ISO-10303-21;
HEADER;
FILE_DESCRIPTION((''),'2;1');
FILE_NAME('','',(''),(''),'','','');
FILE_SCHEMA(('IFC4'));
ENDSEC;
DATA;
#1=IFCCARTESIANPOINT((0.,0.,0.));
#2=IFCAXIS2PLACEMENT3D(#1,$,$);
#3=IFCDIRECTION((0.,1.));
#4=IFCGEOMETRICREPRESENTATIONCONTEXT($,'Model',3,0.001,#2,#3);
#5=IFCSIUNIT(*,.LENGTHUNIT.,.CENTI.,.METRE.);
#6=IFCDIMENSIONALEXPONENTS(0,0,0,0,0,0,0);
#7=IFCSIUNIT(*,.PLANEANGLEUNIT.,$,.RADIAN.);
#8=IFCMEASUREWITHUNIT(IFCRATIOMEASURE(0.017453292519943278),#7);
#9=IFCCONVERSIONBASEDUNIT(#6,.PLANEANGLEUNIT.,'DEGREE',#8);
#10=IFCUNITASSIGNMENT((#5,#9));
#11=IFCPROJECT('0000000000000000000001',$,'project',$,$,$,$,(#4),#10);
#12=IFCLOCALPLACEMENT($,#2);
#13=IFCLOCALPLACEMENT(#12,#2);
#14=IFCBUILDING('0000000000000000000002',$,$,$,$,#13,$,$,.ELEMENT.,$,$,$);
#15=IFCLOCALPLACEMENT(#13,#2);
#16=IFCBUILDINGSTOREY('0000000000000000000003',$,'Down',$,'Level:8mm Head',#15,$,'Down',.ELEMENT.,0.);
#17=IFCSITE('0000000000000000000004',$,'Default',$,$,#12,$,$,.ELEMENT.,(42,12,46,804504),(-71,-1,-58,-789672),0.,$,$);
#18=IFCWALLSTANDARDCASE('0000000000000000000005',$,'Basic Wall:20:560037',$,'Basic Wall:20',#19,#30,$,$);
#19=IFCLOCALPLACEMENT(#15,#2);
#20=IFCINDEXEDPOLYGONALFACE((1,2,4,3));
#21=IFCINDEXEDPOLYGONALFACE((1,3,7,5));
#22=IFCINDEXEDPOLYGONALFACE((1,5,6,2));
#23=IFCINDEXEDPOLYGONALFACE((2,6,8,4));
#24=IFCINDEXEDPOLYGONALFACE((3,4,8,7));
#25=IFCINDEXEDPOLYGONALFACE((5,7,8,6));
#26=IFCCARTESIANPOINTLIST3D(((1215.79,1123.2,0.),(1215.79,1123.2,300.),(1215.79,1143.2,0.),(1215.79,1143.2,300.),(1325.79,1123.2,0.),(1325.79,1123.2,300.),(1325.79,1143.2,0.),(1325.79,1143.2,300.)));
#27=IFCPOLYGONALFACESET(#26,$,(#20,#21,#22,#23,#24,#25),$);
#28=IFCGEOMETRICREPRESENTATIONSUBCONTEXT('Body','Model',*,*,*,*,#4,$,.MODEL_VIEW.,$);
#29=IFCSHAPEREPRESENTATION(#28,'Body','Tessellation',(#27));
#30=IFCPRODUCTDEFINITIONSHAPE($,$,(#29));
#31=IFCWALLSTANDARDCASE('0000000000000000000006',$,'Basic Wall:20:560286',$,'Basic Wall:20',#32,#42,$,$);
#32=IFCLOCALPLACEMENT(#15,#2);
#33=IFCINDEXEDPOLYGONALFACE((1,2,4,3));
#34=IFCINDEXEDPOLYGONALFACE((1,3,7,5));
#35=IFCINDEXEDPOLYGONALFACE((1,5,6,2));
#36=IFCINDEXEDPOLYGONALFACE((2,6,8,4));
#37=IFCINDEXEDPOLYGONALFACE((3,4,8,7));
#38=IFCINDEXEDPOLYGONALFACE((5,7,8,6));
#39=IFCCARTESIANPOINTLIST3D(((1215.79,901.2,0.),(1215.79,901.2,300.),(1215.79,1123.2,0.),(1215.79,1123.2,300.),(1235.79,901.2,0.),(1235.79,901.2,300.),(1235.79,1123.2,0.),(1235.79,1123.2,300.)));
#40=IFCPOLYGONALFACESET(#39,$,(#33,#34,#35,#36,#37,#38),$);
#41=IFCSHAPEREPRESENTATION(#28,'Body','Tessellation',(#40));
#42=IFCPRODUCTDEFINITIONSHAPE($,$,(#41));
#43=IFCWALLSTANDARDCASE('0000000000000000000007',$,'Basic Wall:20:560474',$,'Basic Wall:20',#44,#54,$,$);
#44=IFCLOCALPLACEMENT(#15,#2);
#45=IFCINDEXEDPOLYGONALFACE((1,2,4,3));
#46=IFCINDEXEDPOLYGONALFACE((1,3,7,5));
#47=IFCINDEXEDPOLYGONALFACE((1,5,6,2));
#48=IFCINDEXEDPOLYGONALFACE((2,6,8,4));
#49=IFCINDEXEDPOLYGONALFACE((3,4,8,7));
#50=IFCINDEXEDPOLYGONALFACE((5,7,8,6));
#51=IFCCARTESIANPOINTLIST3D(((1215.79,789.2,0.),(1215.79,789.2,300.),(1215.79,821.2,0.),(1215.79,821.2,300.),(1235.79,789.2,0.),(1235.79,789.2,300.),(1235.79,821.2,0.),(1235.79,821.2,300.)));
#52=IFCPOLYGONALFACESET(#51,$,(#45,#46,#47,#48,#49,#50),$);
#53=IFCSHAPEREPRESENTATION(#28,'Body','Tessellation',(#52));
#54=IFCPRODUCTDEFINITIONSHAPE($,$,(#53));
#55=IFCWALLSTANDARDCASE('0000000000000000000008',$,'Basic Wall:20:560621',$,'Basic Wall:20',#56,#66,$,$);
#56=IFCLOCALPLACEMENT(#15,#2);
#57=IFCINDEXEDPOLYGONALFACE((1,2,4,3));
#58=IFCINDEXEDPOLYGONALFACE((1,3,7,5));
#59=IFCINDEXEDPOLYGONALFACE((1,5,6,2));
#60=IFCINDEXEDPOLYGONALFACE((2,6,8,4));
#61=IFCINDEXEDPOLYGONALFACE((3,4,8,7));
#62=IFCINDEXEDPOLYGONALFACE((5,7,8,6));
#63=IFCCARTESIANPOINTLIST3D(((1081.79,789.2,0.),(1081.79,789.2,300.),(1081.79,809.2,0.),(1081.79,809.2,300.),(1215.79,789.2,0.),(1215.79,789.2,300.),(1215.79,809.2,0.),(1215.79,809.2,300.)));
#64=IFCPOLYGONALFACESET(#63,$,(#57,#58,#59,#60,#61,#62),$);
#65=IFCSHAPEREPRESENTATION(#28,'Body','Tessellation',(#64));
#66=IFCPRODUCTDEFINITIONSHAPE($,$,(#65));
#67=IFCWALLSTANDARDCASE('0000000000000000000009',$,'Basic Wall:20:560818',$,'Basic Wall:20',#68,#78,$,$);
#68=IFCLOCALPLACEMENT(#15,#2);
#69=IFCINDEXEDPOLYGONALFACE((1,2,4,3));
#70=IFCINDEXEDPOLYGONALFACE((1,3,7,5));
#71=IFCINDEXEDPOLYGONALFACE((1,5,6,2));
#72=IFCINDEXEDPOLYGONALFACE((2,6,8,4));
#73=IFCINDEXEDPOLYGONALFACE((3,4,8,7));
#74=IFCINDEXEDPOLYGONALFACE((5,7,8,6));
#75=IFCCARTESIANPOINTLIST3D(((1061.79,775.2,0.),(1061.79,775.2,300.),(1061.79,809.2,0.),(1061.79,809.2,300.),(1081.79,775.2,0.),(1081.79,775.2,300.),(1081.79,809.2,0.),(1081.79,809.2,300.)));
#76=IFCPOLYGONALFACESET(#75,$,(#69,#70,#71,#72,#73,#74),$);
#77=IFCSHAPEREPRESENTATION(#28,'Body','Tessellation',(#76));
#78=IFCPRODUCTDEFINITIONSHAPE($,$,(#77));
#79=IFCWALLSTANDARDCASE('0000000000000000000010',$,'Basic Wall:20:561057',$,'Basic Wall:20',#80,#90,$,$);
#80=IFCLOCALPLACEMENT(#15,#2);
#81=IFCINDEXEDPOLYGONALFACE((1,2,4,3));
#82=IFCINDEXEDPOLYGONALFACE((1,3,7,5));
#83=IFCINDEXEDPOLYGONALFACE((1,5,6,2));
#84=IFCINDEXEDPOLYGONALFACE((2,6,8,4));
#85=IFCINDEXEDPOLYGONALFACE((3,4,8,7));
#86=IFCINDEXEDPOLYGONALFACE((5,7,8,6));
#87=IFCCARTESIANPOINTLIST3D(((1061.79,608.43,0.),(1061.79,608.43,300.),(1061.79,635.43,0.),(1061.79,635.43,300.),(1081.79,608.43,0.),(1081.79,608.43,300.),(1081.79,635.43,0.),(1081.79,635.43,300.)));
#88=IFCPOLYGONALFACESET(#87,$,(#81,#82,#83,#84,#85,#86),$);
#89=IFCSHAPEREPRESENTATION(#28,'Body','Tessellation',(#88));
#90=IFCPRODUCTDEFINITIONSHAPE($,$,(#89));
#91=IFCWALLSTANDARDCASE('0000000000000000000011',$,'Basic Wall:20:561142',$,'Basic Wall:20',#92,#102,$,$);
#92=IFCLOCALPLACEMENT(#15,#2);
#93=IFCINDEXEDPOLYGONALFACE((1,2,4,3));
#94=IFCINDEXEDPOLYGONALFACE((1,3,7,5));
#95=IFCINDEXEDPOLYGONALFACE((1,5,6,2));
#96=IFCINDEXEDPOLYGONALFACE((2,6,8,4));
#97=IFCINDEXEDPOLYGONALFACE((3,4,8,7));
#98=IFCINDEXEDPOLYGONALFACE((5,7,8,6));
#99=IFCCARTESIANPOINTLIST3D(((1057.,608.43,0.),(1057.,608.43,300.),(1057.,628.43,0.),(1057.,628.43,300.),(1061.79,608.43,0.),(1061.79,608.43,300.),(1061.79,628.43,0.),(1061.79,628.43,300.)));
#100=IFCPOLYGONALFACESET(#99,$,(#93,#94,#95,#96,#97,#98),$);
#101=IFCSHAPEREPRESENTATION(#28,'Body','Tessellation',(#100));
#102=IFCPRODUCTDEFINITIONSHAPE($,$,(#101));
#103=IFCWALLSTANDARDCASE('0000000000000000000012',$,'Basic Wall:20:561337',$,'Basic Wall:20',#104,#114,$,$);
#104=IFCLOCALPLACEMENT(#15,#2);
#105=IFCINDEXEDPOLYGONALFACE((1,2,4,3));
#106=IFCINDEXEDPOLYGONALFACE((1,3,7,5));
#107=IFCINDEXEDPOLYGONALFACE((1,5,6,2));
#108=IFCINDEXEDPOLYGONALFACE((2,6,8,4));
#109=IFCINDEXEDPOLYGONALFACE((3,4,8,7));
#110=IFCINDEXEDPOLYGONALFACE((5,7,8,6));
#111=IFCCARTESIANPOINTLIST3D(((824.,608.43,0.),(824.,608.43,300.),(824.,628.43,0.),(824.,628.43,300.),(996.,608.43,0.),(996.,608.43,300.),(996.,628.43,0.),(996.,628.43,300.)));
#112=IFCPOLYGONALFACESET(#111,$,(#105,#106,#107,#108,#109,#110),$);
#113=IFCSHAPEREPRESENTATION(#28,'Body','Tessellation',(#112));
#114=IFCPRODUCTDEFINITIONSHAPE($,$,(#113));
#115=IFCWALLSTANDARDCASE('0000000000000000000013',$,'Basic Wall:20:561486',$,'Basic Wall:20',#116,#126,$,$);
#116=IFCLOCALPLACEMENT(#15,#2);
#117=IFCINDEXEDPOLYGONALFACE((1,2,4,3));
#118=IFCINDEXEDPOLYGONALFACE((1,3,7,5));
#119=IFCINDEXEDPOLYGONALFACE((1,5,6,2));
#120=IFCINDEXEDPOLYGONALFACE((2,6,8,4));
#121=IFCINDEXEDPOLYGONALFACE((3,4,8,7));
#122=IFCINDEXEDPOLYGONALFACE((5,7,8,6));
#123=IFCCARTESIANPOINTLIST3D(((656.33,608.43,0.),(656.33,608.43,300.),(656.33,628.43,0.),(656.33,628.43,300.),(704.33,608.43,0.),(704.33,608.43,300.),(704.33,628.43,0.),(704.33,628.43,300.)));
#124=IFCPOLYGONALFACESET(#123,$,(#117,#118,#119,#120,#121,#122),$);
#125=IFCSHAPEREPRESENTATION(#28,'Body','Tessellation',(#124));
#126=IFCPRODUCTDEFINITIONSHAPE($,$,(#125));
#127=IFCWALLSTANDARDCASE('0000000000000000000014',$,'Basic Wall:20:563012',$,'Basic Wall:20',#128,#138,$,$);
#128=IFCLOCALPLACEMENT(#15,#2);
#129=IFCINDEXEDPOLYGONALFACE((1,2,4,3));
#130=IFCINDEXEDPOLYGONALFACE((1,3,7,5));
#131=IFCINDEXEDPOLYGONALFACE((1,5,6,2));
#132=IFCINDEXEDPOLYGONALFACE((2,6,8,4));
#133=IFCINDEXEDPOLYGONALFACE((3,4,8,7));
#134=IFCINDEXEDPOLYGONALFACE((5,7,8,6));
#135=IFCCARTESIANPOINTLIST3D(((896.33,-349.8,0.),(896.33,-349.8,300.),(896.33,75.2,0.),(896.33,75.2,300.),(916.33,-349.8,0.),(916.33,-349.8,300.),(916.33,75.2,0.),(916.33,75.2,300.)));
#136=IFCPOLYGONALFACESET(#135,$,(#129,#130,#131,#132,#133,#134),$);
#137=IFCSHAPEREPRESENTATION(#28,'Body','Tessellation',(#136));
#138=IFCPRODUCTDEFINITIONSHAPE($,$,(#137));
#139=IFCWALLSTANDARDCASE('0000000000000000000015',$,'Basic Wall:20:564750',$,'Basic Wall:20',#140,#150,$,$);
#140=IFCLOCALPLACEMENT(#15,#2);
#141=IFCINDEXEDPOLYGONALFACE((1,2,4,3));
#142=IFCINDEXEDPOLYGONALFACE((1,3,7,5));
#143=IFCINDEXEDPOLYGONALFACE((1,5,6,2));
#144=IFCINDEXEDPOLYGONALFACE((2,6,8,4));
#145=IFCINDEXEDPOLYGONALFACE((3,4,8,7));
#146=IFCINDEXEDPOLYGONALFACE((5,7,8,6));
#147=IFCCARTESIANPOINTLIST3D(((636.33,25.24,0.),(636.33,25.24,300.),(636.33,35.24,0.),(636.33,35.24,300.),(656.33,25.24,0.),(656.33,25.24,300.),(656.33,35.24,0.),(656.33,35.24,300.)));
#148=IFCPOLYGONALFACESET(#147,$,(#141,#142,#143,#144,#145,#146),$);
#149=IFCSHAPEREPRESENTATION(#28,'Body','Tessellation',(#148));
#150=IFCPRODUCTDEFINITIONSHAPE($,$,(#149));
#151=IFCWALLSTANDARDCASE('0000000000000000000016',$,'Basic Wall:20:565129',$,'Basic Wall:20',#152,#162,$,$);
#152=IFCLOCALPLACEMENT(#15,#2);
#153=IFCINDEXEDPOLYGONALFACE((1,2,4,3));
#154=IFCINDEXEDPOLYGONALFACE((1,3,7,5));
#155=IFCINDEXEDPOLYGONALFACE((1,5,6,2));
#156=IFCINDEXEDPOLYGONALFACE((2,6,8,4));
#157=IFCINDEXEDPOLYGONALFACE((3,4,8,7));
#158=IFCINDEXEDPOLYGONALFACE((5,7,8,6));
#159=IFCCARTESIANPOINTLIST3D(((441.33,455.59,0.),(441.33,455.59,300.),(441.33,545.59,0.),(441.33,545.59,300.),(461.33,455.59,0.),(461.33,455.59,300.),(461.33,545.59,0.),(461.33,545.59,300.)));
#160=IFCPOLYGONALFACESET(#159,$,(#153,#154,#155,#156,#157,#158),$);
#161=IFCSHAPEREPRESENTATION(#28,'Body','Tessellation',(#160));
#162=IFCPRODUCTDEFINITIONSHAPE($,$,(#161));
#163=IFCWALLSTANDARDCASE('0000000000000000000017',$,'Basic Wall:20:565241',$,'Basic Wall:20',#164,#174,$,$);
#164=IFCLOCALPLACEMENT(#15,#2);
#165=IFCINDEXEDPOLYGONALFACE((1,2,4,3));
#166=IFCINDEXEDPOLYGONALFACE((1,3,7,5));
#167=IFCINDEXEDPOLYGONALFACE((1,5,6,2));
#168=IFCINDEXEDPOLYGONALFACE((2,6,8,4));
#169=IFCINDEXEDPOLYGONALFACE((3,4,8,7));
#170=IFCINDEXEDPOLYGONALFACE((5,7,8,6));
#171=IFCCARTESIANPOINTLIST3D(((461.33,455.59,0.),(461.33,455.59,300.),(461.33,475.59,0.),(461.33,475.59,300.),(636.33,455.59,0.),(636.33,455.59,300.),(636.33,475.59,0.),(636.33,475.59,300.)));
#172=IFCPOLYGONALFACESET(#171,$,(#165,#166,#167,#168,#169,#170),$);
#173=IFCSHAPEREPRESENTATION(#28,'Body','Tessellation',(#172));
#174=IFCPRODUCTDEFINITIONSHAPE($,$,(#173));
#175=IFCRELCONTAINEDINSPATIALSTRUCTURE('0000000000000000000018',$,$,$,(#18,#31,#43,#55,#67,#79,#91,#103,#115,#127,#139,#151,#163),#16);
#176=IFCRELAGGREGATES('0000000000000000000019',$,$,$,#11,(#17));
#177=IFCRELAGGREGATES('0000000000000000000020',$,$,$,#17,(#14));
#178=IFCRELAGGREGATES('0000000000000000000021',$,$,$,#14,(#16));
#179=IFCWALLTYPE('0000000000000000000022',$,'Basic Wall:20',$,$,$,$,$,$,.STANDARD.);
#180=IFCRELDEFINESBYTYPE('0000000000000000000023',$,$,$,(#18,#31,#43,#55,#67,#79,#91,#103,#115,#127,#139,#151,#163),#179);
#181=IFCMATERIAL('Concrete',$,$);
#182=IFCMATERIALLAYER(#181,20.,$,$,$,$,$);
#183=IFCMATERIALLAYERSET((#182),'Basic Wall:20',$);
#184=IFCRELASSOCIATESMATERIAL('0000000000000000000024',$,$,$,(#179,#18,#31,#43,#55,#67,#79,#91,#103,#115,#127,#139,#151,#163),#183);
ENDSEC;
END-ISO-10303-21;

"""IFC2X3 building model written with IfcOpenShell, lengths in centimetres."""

from ifc_helpers import new_model, entity, si_unit, converted_unit, direction, frame, frame_2d, origin, place, context, subcontext, project, spatial, rectangle, extrude, material, layer, layer_set, layer_usage, type_object, element, save


model = new_model("IFC2X3")

# Units and contexts
model_context = context("Model", 3, precision=0.001, world=origin(), true_north=direction((0.0, 1.0)))
body_context = subcontext(model_context, "Body", "Model", "MODEL_VIEW")
ifc_project = project(units=[si_unit("LENGTHUNIT", "METRE", prefix="CENTI"), converted_unit("PLANEANGLEUNIT", "DEGREE", entity("IfcRatioMeasure", 0.017453292519943278), si_unit("PLANEANGLEUNIT", "RADIAN"), dimensions=[0, 0, 0, 0, 0, 0, 0])], contexts=[model_context])

# Site, building, storey
site_placement = place(None, origin())
site = spatial("IfcSite", under=ifc_project, at=site_placement, Name="Default", CompositionType="ELEMENT", RefLatitude=(42, 12, 46, 804504), RefLongitude=(-71, -1, -58, -789672), RefElevation=0.0)
building_placement = place(site_placement, origin())
building = spatial("IfcBuilding", under=site, at=building_placement, CompositionType="ELEMENT")
storey_placement = place(building_placement, origin())
storey = spatial("IfcBuildingStorey", under=building, at=storey_placement, Name="Down", ObjectType="Level:8mm Head", LongName="Down", CompositionType="ELEMENT", Elevation=0.0)

# Walls
ifc_material = material(Name="Concrete")
ifc_layer_1 = layer(ifc_material, 20.0)
ifc_layer_set_1 = layer_set([ifc_layer_1], Name="Basic Wall:20")
wall_type_1 = type_object("IfcWallType", Name="Basic Wall:20", PredefinedType="STANDARD", material=ifc_layer_set_1)
ifc_layer_usage_1 = layer_usage(ifc_layer_set_1, "AXIS2", "POSITIVE", -10.0)
wall_1_placement = place(storey_placement, frame((1325.79, 1133.2, 0.0), z_axis=(0.0, 0.0, 1.0), x_axis=(-1.0, 0.0, 0.0)))
element("IfcWallStandardCase", 1, at=wall_1_placement, inside=storey, type_object=wall_type_1, material=ifc_layer_usage_1, Name="Basic Wall:20:560037", ObjectType="Basic Wall:20", context=body_context, shape_type="SweptSolid", body=[
    extrude(rectangle(XDim=110.0, YDim=20.0, at=frame_2d((55.0, 0.0), x_axis=(-1.0, 0.0))), origin(), (0.0, 0.0, 1.0), 300.0),
])
ifc_layer_usage_2 = layer_usage(ifc_layer_set_1, "AXIS2", "NEGATIVE", 10.0)
wall_2_placement = place(storey_placement, frame((1225.79, 1123.2, 0.0), z_axis=(0.0, 0.0, 1.0), x_axis=(0.0, -1.0, 0.0)))
element("IfcWallStandardCase", 2, at=wall_2_placement, inside=storey, type_object=wall_type_1, material=ifc_layer_usage_2, Name="Basic Wall:20:560286", ObjectType="Basic Wall:20", context=body_context, shape_type="SweptSolid", body=[
    extrude(rectangle(XDim=222.0, YDim=20.0, at=frame_2d((111.0, 0.0), x_axis=(-1.0, 0.0))), origin(), (0.0, 0.0, 1.0), 300.0),
])
ifc_layer_usage_3 = layer_usage(ifc_layer_set_1, "AXIS2", "NEGATIVE", 10.0)
wall_3_placement = place(storey_placement, frame((1225.79, 821.2, 0.0), z_axis=(0.0, 0.0, 1.0), x_axis=(0.0, -1.0, 0.0)))
element("IfcWallStandardCase", 3, at=wall_3_placement, inside=storey, type_object=wall_type_1, material=ifc_layer_usage_3, Name="Basic Wall:20:560474", ObjectType="Basic Wall:20", context=body_context, shape_type="SweptSolid", body=[
    extrude(rectangle(XDim=32.0, YDim=20.0, at=frame_2d((16.0, 0.0), x_axis=(-1.0, 0.0))), origin(), (0.0, 0.0, 1.0), 300.0),
])
ifc_layer_usage_4 = layer_usage(ifc_layer_set_1, "AXIS2", "NEGATIVE", 10.0)
wall_4_placement = place(storey_placement, frame((1215.79, 799.2, 0.0), z_axis=(0.0, 0.0, 1.0), x_axis=(-1.0, 0.0, 0.0)))
element("IfcWallStandardCase", 4, at=wall_4_placement, inside=storey, type_object=wall_type_1, material=ifc_layer_usage_4, Name="Basic Wall:20:560621", ObjectType="Basic Wall:20", context=body_context, shape_type="SweptSolid", body=[
    extrude(rectangle(XDim=134.0, YDim=20.0, at=frame_2d((67.0, 0.0), x_axis=(-1.0, 0.0))), origin(), (0.0, 0.0, 1.0), 300.0),
])
ifc_layer_usage_5 = layer_usage(ifc_layer_set_1, "AXIS2", "NEGATIVE", 10.0)
wall_5_placement = place(storey_placement, frame((1071.79, 809.2, 0.0), z_axis=(0.0, 0.0, 1.0), x_axis=(0.0, -1.0, 0.0)))
element("IfcWallStandardCase", 5, at=wall_5_placement, inside=storey, type_object=wall_type_1, material=ifc_layer_usage_5, Name="Basic Wall:20:560818", ObjectType="Basic Wall:20", context=body_context, shape_type="SweptSolid", body=[
    extrude(rectangle(XDim=34.0, YDim=20.0, at=frame_2d((17.0, 0.0), x_axis=(-1.0, 0.0))), origin(), (0.0, 0.0, 1.0), 300.0),
])
ifc_layer_usage_6 = layer_usage(ifc_layer_set_1, "AXIS2", "NEGATIVE", 10.0)
wall_6_placement = place(storey_placement, frame((1071.79, 635.43, 0.0), z_axis=(0.0, 0.0, 1.0), x_axis=(0.0, -1.0, 0.0)))
element("IfcWallStandardCase", 6, at=wall_6_placement, inside=storey, type_object=wall_type_1, material=ifc_layer_usage_6, Name="Basic Wall:20:561057", ObjectType="Basic Wall:20", context=body_context, shape_type="SweptSolid", body=[
    extrude(rectangle(XDim=27.0, YDim=20.0, at=frame_2d((13.5, 0.0), x_axis=(-1.0, 0.0))), origin(), (0.0, 0.0, 1.0), 300.0),
])
ifc_layer_usage_7 = layer_usage(ifc_layer_set_1, "AXIS2", "NEGATIVE", 10.0)
wall_7_placement = place(storey_placement, frame((1061.79, 618.43, 0.0), z_axis=(0.0, 0.0, 1.0), x_axis=(-1.0, 0.0, 0.0)))
element("IfcWallStandardCase", 7, at=wall_7_placement, inside=storey, type_object=wall_type_1, material=ifc_layer_usage_7, Name="Basic Wall:20:561142", ObjectType="Basic Wall:20", context=body_context, shape_type="SweptSolid", body=[
    extrude(rectangle(XDim=4.79, YDim=20.0, at=frame_2d((2.4, 0.0), x_axis=(-1.0, 0.0))), origin(), (0.0, 0.0, 1.0), 300.0),
])
ifc_layer_usage_8 = layer_usage(ifc_layer_set_1, "AXIS2", "NEGATIVE", 10.0)
wall_8_placement = place(storey_placement, frame((996.0, 618.43, 0.0), z_axis=(0.0, 0.0, 1.0), x_axis=(-1.0, 0.0, 0.0)))
element("IfcWallStandardCase", 8, at=wall_8_placement, inside=storey, type_object=wall_type_1, material=ifc_layer_usage_8, Name="Basic Wall:20:561337", ObjectType="Basic Wall:20", context=body_context, shape_type="SweptSolid", body=[
    extrude(rectangle(XDim=172.0, YDim=20.0, at=frame_2d((86.0, 0.0), x_axis=(-1.0, 0.0))), origin(), (0.0, 0.0, 1.0), 300.0),
])
ifc_layer_usage_9 = layer_usage(ifc_layer_set_1, "AXIS2", "NEGATIVE", 10.0)
wall_9_placement = place(storey_placement, frame((704.33, 618.43, 0.0), z_axis=(0.0, 0.0, 1.0), x_axis=(-1.0, 0.0, 0.0)))
element("IfcWallStandardCase", 9, at=wall_9_placement, inside=storey, type_object=wall_type_1, material=ifc_layer_usage_9, Name="Basic Wall:20:561486", ObjectType="Basic Wall:20", context=body_context, shape_type="SweptSolid", body=[
    extrude(rectangle(XDim=48.0, YDim=20.0, at=frame_2d((24.0, 0.0), x_axis=(-1.0, 0.0))), origin(), (0.0, 0.0, 1.0), 300.0),
])
ifc_layer_usage_10 = layer_usage(ifc_layer_set_1, "AXIS2", "NEGATIVE", 10.0)
wall_10_placement = place(storey_placement, frame((906.33, 75.2, 0.0), z_axis=(0.0, 0.0, 1.0), x_axis=(0.0, -1.0, 0.0)))
element("IfcWallStandardCase", 10, at=wall_10_placement, inside=storey, type_object=wall_type_1, material=ifc_layer_usage_10, Name="Basic Wall:20:563012", ObjectType="Basic Wall:20", context=body_context, shape_type="SweptSolid", body=[
    extrude(rectangle(XDim=425.0, YDim=20.0, at=frame_2d((212.5, 0.0), x_axis=(-1.0, 0.0))), origin(), (0.0, 0.0, 1.0), 300.0),
])
ifc_layer_usage_11 = layer_usage(ifc_layer_set_1, "AXIS2", "NEGATIVE", 10.0)
wall_11_placement = place(storey_placement, frame((646.33, 35.24, 0.0), z_axis=(0.0, 0.0, 1.0), x_axis=(0.0, -1.0, 0.0)))
element("IfcWallStandardCase", 11, at=wall_11_placement, inside=storey, type_object=wall_type_1, material=ifc_layer_usage_11, Name="Basic Wall:20:564750", ObjectType="Basic Wall:20", context=body_context, shape_type="SweptSolid", body=[
    extrude(rectangle(XDim=10.0, YDim=20.0, at=frame_2d((5.0, 0.0), x_axis=(-1.0, 0.0))), origin(), (0.0, 0.0, 1.0), 300.0),
])
ifc_layer_usage_12 = layer_usage(ifc_layer_set_1, "AXIS2", "POSITIVE", -10.0)
wall_12_placement = place(storey_placement, frame((451.33, 545.59, 0.0), z_axis=(0.0, 0.0, 1.0), x_axis=(0.0, -1.0, 0.0)))
element("IfcWallStandardCase", 12, at=wall_12_placement, inside=storey, type_object=wall_type_1, material=ifc_layer_usage_12, Name="Basic Wall:20:565129", ObjectType="Basic Wall:20", context=body_context, shape_type="SweptSolid", body=[
    extrude(rectangle(XDim=90.0, YDim=20.0, at=frame_2d((45.0, 0.0), x_axis=(-1.0, 0.0))), origin(), (0.0, 0.0, 1.0), 300.0),
])
ifc_layer_usage_13 = layer_usage(ifc_layer_set_1, "AXIS2", "POSITIVE", -10.0)
wall_13_placement = place(storey_placement, frame((461.33, 465.59, 0.0)))
element("IfcWallStandardCase", 13, at=wall_13_placement, inside=storey, type_object=wall_type_1, material=ifc_layer_usage_13, Name="Basic Wall:20:565241", ObjectType="Basic Wall:20", context=body_context, shape_type="SweptSolid", body=[
    extrude(rectangle(XDim=175.0, YDim=20.0, at=frame_2d((87.5, 0.0), x_axis=(-1.0, 0.0))), origin(), (0.0, 0.0, 1.0), 300.0),
])

save(model, "model.ifc")
